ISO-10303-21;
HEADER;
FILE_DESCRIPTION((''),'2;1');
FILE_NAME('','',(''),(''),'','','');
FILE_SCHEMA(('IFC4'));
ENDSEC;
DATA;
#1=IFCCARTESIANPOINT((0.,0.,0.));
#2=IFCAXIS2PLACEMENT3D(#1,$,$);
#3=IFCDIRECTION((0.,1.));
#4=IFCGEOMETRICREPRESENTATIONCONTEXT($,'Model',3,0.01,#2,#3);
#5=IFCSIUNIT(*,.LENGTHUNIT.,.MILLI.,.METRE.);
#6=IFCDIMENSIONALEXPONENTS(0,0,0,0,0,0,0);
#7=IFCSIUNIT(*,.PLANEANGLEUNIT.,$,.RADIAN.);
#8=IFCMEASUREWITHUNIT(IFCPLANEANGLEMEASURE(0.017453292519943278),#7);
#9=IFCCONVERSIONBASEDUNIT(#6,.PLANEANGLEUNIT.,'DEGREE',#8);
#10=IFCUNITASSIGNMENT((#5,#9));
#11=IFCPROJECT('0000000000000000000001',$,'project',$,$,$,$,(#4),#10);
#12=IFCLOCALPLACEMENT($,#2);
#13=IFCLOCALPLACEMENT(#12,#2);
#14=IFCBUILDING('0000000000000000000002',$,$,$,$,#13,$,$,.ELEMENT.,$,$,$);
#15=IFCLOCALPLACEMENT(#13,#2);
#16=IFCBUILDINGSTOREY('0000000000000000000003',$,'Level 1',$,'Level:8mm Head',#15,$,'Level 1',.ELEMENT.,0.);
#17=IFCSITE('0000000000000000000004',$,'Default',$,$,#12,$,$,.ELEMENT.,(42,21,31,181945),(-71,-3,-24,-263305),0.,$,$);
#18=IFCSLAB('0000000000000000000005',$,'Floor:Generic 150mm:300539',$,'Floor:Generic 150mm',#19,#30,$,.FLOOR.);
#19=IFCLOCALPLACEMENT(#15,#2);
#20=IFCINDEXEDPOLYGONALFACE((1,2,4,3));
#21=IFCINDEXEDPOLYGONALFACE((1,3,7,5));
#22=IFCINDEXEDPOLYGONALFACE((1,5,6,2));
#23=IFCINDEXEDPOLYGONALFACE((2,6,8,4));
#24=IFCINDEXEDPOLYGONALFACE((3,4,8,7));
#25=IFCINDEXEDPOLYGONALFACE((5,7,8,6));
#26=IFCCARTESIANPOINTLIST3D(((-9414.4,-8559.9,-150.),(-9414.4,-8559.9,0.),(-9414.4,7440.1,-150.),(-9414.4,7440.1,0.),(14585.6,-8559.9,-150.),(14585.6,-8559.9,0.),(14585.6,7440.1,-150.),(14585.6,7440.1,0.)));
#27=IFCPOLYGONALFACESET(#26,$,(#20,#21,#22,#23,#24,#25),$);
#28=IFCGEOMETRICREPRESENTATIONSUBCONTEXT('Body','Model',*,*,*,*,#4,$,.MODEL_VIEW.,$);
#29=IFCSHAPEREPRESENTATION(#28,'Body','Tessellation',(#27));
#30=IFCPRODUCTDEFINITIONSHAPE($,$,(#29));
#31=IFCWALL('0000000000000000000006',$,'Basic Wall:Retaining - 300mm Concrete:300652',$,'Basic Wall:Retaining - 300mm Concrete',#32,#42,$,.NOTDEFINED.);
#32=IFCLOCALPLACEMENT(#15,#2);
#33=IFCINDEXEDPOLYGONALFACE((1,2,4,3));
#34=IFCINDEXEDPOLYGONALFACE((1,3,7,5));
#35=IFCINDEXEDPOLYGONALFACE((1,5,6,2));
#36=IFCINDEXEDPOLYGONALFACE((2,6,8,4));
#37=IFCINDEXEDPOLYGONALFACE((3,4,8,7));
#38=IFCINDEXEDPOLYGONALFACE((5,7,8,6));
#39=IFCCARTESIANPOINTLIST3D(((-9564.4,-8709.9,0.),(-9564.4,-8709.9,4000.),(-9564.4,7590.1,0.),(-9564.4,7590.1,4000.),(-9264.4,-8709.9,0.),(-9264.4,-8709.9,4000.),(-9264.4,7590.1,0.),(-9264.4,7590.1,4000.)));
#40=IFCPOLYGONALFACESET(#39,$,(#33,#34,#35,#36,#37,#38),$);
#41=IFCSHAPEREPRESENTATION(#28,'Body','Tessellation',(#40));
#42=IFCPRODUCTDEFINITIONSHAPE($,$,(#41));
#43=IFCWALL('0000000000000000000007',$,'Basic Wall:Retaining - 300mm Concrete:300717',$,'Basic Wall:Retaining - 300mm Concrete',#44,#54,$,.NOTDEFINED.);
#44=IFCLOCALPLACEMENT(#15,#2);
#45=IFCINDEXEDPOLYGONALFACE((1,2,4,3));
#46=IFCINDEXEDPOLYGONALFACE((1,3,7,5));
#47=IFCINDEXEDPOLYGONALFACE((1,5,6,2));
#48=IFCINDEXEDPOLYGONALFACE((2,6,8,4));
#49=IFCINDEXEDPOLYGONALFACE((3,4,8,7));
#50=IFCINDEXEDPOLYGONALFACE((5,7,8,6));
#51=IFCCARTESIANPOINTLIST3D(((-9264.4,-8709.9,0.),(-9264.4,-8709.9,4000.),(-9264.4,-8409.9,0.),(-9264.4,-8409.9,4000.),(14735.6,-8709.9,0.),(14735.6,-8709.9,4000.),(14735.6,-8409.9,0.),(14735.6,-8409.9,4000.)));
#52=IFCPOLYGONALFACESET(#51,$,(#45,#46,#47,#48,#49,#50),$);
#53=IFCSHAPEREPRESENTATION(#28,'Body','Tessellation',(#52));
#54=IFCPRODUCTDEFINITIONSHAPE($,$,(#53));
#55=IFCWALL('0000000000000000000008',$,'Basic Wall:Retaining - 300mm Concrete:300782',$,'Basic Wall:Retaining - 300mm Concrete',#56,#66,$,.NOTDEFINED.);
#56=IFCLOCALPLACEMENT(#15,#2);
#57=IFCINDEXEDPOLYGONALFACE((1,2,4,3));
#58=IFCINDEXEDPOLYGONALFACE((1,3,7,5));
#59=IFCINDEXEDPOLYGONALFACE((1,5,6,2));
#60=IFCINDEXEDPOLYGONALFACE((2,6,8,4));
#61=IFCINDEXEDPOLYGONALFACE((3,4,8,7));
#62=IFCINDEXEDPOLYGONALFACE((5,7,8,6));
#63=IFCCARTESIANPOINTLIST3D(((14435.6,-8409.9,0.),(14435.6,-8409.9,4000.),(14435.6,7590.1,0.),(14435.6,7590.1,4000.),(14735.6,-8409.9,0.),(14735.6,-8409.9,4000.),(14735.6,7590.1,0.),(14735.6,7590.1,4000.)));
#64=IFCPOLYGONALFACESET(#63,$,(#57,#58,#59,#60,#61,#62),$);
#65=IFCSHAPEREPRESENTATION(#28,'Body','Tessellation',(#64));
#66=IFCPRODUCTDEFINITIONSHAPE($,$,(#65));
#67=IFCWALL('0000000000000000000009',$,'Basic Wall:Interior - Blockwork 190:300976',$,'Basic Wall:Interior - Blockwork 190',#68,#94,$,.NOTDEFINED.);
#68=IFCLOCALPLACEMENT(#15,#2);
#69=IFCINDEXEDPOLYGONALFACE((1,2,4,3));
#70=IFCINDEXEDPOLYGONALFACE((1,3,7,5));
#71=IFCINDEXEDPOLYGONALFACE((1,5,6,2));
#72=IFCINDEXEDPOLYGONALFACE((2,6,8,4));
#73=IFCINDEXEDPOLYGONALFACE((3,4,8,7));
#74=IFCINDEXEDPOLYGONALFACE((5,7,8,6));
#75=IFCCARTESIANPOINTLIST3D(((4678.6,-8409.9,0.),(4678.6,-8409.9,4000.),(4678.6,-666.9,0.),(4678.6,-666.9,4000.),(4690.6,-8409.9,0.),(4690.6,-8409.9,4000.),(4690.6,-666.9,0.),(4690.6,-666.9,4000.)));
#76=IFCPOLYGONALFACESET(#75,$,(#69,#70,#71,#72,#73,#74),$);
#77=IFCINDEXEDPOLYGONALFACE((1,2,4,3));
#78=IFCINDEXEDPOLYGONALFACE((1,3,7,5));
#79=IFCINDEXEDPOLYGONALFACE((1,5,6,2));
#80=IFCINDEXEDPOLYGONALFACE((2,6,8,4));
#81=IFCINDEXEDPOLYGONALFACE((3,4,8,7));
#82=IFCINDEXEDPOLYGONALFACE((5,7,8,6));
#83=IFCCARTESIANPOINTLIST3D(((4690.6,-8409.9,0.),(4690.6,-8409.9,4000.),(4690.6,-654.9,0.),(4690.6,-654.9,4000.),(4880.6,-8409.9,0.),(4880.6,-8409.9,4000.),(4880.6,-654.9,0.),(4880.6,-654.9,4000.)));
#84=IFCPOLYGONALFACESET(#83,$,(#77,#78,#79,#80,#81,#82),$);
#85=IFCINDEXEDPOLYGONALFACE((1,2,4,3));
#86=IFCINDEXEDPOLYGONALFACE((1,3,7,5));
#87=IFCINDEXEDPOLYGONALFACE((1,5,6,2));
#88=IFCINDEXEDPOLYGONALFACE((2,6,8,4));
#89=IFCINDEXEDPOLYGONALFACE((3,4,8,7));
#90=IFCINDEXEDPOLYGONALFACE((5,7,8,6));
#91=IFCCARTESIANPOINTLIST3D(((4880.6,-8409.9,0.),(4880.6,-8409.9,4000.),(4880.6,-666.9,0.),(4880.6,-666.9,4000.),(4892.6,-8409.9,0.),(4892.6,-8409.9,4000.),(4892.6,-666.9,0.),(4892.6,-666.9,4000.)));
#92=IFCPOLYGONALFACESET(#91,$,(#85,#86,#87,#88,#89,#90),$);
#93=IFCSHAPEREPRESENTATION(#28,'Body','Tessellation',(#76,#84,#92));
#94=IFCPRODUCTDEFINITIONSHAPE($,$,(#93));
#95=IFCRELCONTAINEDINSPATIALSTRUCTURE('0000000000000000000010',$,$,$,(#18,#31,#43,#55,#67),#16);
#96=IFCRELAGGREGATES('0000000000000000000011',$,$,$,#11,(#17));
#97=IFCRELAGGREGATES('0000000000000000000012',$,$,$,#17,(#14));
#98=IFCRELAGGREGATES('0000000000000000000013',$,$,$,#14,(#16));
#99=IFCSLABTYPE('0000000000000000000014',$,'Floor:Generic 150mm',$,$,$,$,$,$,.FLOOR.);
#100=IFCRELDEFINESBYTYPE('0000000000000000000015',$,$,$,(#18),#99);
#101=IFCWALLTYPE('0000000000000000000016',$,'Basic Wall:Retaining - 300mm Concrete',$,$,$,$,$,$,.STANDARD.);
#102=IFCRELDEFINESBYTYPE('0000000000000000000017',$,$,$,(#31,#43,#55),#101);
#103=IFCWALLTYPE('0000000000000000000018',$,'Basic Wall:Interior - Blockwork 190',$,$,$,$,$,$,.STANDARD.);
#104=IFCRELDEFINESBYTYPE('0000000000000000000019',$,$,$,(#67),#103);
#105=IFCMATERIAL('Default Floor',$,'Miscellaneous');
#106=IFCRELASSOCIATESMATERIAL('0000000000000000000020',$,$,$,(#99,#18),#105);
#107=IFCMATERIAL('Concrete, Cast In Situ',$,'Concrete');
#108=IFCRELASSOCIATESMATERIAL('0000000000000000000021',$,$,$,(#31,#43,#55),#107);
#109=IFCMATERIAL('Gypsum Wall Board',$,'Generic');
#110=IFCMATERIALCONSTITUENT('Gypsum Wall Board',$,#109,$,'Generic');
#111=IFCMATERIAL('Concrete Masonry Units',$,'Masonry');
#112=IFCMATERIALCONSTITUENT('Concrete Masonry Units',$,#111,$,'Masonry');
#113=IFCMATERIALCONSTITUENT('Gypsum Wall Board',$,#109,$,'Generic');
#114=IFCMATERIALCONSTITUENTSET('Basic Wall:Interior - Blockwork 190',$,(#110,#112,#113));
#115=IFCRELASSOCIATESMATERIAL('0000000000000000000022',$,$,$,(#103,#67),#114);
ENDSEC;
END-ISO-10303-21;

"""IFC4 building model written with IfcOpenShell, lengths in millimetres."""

from ifc_helpers import new_model, entity, si_unit, converted_unit, direction, frame, origin, place, context, subcontext, project, spatial, indexed_curve, outline, extrude, material, constituent, constituent_set, type_object, element, save


model = new_model("IFC4")

# Units and contexts
model_context = context("Model", 3, precision=0.01, world=origin(), true_north=direction((0.0, 1.0)))
body_context = subcontext(model_context, "Body", "Model", "MODEL_VIEW")
ifc_project = project(units=[si_unit("LENGTHUNIT", "METRE", prefix="MILLI"), converted_unit("PLANEANGLEUNIT", "DEGREE", entity("IfcPlaneAngleMeasure", 0.017453292519943278), si_unit("PLANEANGLEUNIT", "RADIAN"), dimensions=[0, 0, 0, 0, 0, 0, 0])], contexts=[model_context])

# Site, building, storey
site_placement = place(None, origin())
site = spatial("IfcSite", under=ifc_project, at=site_placement, Name="Default", CompositionType="ELEMENT", RefLatitude=(42, 21, 31, 181945), RefLongitude=(-71, -3, -24, -263305), RefElevation=0.0)
building_placement = place(site_placement, origin())
building = spatial("IfcBuilding", under=site, at=building_placement, CompositionType="ELEMENT")
storey_placement = place(building_placement, origin())
storey = spatial("IfcBuildingStorey", under=building, at=storey_placement, Name="Level 1", ObjectType="Level:8mm Head", LongName="Level 1", CompositionType="ELEMENT", Elevation=0.0)

# Slab
ifc_material_1 = material(Name="Default Floor", Category="Miscellaneous")
slab_type = type_object("IfcSlabType", Name="Floor:Generic 150mm", PredefinedType="FLOOR", material=ifc_material_1)
slab_placement = place(storey_placement, origin())
element("IfcSlab", 1, at=slab_placement, inside=storey, type_object=slab_type, material=ifc_material_1, Name="Floor:Generic 150mm:300539", ObjectType="Floor:Generic 150mm", PredefinedType="FLOOR", context=body_context, shape_type="SweptSolid", body=[
    extrude(outline(indexed_curve([(-8000.0, -12000.0), (8000.0, -12000.0), (8000.0, 12000.0), (-8000.0, 12000.0), (-8000.0, -12000.0)], self_intersect=False)), frame((2585.6, -559.9, 0.0), z_axis=(0.0, 0.0, -1.0), x_axis=(0.0, 1.0, 0.0)), (0.0, 0.0, 1.0), 150.0),
])

# Walls
ifc_material_2 = material(Name="Concrete, Cast In Situ", Category="Concrete")
wall_type_1 = type_object("IfcWallType", Name="Basic Wall:Retaining - 300mm Concrete", PredefinedType="STANDARD")
wall_1_placement = place(storey_placement, frame((-9414.4, 7590.1, 0.0), z_axis=(0.0, 0.0, 1.0), x_axis=(0.0, -1.0, 0.0)))
element("IfcWall", 2, at=wall_1_placement, inside=storey, type_object=wall_type_1, material=ifc_material_2, Name="Basic Wall:Retaining - 300mm Concrete:300652", ObjectType="Basic Wall:Retaining - 300mm Concrete", PredefinedType="NOTDEFINED", context=body_context, shape_type="SweptSolid", body=[
    extrude(outline(indexed_curve([(16300.0, 150.0), (0.0, 150.0), (0.0, -150.0), (16300.0, -150.0), (16300.0, 150.0)], self_intersect=False)), origin(), (0.0, 0.0, 1.0), 4000.0),
])
wall_2_placement = place(storey_placement, frame((-9264.4, -8559.9, 0.0)))
element("IfcWall", 3, at=wall_2_placement, inside=storey, type_object=wall_type_1, material=ifc_material_2, Name="Basic Wall:Retaining - 300mm Concrete:300717", ObjectType="Basic Wall:Retaining - 300mm Concrete", PredefinedType="NOTDEFINED", context=body_context, shape_type="SweptSolid", body=[
    extrude(outline(indexed_curve([(24000.0, 150.0), (0.0, 150.0), (0.0, -150.0), (24000.0, -150.0), (24000.0, 150.0)], self_intersect=False)), origin(), (0.0, 0.0, 1.0), 4000.0),
])
wall_3_placement = place(storey_placement, frame((14585.6, -8409.9, 0.0), z_axis=(0.0, 0.0, 1.0), x_axis=(0.0, 1.0, 0.0)))
element("IfcWall", 4, at=wall_3_placement, inside=storey, type_object=wall_type_1, material=ifc_material_2, Name="Basic Wall:Retaining - 300mm Concrete:300782", ObjectType="Basic Wall:Retaining - 300mm Concrete", PredefinedType="NOTDEFINED", context=body_context, shape_type="SweptSolid", body=[
    extrude(outline(indexed_curve([(16000.0, 150.0), (0.0, 150.0), (0.0, -150.0), (16000.0, -150.0), (16000.0, 150.0)], self_intersect=False)), origin(), (0.0, 0.0, 1.0), 4000.0),
])
ifc_material_3 = material(Name="Gypsum Wall Board", Category="Generic")
ifc_constituent_1 = constituent(ifc_material_3, Name="Gypsum Wall Board", Category="Generic")
ifc_material_4 = material(Name="Concrete Masonry Units", Category="Masonry")
ifc_constituent_2 = constituent(ifc_material_4, Name="Concrete Masonry Units", Category="Masonry")
ifc_constituent_3 = constituent(ifc_material_3, Name="Gypsum Wall Board", Category="Generic")
ifc_constituent_set = constituent_set(constituents=[ifc_constituent_1, ifc_constituent_2, ifc_constituent_3], Name="Basic Wall:Interior - Blockwork 190")
wall_type_2 = type_object("IfcWallType", Name="Basic Wall:Interior - Blockwork 190", PredefinedType="STANDARD", material=ifc_constituent_set)
wall_4_placement = place(storey_placement, frame((4785.6, -666.9, 0.0), z_axis=(0.0, 0.0, 1.0), x_axis=(0.0, -1.0, 0.0)))
element("IfcWall", 5, at=wall_4_placement, inside=storey, type_object=wall_type_2, material=ifc_constituent_set, Name="Basic Wall:Interior - Blockwork 190:300976", ObjectType="Basic Wall:Interior - Blockwork 190", PredefinedType="NOTDEFINED", context=body_context, shape_type="SweptSolid", body=[
    extrude(outline(indexed_curve([(-6.0, -3871.5), (6.0, -3871.5), (6.0, 3871.5), (-6.0, 3871.5), (-6.0, -3871.5)], self_intersect=False)), frame((3871.5, -101.0, 0.0), z_axis=(0.0, 0.0, 1.0), x_axis=(0.0, 1.0, 0.0)), (0.0, 0.0, 1.0), 4000.0),
    extrude(outline(indexed_curve([(-3877.5, -95.0), (3877.5, -95.0), (3877.5, 95.0), (-3877.5, 95.0), (-3877.5, -95.0)], self_intersect=False)), frame((3865.5, 0.0, 0.0)), (0.0, 0.0, 1.0), 4000.0),
    extrude(outline(indexed_curve([(-6.0, -3871.5), (6.0, -3871.5), (6.0, 3871.5), (-6.0, 3871.5), (-6.0, -3871.5)], self_intersect=False)), frame((3871.5, 101.0, 0.0), z_axis=(0.0, 0.0, 1.0), x_axis=(0.0, -1.0, 0.0)), (0.0, 0.0, 1.0), 4000.0),
])

save(model, "model.ifc")
